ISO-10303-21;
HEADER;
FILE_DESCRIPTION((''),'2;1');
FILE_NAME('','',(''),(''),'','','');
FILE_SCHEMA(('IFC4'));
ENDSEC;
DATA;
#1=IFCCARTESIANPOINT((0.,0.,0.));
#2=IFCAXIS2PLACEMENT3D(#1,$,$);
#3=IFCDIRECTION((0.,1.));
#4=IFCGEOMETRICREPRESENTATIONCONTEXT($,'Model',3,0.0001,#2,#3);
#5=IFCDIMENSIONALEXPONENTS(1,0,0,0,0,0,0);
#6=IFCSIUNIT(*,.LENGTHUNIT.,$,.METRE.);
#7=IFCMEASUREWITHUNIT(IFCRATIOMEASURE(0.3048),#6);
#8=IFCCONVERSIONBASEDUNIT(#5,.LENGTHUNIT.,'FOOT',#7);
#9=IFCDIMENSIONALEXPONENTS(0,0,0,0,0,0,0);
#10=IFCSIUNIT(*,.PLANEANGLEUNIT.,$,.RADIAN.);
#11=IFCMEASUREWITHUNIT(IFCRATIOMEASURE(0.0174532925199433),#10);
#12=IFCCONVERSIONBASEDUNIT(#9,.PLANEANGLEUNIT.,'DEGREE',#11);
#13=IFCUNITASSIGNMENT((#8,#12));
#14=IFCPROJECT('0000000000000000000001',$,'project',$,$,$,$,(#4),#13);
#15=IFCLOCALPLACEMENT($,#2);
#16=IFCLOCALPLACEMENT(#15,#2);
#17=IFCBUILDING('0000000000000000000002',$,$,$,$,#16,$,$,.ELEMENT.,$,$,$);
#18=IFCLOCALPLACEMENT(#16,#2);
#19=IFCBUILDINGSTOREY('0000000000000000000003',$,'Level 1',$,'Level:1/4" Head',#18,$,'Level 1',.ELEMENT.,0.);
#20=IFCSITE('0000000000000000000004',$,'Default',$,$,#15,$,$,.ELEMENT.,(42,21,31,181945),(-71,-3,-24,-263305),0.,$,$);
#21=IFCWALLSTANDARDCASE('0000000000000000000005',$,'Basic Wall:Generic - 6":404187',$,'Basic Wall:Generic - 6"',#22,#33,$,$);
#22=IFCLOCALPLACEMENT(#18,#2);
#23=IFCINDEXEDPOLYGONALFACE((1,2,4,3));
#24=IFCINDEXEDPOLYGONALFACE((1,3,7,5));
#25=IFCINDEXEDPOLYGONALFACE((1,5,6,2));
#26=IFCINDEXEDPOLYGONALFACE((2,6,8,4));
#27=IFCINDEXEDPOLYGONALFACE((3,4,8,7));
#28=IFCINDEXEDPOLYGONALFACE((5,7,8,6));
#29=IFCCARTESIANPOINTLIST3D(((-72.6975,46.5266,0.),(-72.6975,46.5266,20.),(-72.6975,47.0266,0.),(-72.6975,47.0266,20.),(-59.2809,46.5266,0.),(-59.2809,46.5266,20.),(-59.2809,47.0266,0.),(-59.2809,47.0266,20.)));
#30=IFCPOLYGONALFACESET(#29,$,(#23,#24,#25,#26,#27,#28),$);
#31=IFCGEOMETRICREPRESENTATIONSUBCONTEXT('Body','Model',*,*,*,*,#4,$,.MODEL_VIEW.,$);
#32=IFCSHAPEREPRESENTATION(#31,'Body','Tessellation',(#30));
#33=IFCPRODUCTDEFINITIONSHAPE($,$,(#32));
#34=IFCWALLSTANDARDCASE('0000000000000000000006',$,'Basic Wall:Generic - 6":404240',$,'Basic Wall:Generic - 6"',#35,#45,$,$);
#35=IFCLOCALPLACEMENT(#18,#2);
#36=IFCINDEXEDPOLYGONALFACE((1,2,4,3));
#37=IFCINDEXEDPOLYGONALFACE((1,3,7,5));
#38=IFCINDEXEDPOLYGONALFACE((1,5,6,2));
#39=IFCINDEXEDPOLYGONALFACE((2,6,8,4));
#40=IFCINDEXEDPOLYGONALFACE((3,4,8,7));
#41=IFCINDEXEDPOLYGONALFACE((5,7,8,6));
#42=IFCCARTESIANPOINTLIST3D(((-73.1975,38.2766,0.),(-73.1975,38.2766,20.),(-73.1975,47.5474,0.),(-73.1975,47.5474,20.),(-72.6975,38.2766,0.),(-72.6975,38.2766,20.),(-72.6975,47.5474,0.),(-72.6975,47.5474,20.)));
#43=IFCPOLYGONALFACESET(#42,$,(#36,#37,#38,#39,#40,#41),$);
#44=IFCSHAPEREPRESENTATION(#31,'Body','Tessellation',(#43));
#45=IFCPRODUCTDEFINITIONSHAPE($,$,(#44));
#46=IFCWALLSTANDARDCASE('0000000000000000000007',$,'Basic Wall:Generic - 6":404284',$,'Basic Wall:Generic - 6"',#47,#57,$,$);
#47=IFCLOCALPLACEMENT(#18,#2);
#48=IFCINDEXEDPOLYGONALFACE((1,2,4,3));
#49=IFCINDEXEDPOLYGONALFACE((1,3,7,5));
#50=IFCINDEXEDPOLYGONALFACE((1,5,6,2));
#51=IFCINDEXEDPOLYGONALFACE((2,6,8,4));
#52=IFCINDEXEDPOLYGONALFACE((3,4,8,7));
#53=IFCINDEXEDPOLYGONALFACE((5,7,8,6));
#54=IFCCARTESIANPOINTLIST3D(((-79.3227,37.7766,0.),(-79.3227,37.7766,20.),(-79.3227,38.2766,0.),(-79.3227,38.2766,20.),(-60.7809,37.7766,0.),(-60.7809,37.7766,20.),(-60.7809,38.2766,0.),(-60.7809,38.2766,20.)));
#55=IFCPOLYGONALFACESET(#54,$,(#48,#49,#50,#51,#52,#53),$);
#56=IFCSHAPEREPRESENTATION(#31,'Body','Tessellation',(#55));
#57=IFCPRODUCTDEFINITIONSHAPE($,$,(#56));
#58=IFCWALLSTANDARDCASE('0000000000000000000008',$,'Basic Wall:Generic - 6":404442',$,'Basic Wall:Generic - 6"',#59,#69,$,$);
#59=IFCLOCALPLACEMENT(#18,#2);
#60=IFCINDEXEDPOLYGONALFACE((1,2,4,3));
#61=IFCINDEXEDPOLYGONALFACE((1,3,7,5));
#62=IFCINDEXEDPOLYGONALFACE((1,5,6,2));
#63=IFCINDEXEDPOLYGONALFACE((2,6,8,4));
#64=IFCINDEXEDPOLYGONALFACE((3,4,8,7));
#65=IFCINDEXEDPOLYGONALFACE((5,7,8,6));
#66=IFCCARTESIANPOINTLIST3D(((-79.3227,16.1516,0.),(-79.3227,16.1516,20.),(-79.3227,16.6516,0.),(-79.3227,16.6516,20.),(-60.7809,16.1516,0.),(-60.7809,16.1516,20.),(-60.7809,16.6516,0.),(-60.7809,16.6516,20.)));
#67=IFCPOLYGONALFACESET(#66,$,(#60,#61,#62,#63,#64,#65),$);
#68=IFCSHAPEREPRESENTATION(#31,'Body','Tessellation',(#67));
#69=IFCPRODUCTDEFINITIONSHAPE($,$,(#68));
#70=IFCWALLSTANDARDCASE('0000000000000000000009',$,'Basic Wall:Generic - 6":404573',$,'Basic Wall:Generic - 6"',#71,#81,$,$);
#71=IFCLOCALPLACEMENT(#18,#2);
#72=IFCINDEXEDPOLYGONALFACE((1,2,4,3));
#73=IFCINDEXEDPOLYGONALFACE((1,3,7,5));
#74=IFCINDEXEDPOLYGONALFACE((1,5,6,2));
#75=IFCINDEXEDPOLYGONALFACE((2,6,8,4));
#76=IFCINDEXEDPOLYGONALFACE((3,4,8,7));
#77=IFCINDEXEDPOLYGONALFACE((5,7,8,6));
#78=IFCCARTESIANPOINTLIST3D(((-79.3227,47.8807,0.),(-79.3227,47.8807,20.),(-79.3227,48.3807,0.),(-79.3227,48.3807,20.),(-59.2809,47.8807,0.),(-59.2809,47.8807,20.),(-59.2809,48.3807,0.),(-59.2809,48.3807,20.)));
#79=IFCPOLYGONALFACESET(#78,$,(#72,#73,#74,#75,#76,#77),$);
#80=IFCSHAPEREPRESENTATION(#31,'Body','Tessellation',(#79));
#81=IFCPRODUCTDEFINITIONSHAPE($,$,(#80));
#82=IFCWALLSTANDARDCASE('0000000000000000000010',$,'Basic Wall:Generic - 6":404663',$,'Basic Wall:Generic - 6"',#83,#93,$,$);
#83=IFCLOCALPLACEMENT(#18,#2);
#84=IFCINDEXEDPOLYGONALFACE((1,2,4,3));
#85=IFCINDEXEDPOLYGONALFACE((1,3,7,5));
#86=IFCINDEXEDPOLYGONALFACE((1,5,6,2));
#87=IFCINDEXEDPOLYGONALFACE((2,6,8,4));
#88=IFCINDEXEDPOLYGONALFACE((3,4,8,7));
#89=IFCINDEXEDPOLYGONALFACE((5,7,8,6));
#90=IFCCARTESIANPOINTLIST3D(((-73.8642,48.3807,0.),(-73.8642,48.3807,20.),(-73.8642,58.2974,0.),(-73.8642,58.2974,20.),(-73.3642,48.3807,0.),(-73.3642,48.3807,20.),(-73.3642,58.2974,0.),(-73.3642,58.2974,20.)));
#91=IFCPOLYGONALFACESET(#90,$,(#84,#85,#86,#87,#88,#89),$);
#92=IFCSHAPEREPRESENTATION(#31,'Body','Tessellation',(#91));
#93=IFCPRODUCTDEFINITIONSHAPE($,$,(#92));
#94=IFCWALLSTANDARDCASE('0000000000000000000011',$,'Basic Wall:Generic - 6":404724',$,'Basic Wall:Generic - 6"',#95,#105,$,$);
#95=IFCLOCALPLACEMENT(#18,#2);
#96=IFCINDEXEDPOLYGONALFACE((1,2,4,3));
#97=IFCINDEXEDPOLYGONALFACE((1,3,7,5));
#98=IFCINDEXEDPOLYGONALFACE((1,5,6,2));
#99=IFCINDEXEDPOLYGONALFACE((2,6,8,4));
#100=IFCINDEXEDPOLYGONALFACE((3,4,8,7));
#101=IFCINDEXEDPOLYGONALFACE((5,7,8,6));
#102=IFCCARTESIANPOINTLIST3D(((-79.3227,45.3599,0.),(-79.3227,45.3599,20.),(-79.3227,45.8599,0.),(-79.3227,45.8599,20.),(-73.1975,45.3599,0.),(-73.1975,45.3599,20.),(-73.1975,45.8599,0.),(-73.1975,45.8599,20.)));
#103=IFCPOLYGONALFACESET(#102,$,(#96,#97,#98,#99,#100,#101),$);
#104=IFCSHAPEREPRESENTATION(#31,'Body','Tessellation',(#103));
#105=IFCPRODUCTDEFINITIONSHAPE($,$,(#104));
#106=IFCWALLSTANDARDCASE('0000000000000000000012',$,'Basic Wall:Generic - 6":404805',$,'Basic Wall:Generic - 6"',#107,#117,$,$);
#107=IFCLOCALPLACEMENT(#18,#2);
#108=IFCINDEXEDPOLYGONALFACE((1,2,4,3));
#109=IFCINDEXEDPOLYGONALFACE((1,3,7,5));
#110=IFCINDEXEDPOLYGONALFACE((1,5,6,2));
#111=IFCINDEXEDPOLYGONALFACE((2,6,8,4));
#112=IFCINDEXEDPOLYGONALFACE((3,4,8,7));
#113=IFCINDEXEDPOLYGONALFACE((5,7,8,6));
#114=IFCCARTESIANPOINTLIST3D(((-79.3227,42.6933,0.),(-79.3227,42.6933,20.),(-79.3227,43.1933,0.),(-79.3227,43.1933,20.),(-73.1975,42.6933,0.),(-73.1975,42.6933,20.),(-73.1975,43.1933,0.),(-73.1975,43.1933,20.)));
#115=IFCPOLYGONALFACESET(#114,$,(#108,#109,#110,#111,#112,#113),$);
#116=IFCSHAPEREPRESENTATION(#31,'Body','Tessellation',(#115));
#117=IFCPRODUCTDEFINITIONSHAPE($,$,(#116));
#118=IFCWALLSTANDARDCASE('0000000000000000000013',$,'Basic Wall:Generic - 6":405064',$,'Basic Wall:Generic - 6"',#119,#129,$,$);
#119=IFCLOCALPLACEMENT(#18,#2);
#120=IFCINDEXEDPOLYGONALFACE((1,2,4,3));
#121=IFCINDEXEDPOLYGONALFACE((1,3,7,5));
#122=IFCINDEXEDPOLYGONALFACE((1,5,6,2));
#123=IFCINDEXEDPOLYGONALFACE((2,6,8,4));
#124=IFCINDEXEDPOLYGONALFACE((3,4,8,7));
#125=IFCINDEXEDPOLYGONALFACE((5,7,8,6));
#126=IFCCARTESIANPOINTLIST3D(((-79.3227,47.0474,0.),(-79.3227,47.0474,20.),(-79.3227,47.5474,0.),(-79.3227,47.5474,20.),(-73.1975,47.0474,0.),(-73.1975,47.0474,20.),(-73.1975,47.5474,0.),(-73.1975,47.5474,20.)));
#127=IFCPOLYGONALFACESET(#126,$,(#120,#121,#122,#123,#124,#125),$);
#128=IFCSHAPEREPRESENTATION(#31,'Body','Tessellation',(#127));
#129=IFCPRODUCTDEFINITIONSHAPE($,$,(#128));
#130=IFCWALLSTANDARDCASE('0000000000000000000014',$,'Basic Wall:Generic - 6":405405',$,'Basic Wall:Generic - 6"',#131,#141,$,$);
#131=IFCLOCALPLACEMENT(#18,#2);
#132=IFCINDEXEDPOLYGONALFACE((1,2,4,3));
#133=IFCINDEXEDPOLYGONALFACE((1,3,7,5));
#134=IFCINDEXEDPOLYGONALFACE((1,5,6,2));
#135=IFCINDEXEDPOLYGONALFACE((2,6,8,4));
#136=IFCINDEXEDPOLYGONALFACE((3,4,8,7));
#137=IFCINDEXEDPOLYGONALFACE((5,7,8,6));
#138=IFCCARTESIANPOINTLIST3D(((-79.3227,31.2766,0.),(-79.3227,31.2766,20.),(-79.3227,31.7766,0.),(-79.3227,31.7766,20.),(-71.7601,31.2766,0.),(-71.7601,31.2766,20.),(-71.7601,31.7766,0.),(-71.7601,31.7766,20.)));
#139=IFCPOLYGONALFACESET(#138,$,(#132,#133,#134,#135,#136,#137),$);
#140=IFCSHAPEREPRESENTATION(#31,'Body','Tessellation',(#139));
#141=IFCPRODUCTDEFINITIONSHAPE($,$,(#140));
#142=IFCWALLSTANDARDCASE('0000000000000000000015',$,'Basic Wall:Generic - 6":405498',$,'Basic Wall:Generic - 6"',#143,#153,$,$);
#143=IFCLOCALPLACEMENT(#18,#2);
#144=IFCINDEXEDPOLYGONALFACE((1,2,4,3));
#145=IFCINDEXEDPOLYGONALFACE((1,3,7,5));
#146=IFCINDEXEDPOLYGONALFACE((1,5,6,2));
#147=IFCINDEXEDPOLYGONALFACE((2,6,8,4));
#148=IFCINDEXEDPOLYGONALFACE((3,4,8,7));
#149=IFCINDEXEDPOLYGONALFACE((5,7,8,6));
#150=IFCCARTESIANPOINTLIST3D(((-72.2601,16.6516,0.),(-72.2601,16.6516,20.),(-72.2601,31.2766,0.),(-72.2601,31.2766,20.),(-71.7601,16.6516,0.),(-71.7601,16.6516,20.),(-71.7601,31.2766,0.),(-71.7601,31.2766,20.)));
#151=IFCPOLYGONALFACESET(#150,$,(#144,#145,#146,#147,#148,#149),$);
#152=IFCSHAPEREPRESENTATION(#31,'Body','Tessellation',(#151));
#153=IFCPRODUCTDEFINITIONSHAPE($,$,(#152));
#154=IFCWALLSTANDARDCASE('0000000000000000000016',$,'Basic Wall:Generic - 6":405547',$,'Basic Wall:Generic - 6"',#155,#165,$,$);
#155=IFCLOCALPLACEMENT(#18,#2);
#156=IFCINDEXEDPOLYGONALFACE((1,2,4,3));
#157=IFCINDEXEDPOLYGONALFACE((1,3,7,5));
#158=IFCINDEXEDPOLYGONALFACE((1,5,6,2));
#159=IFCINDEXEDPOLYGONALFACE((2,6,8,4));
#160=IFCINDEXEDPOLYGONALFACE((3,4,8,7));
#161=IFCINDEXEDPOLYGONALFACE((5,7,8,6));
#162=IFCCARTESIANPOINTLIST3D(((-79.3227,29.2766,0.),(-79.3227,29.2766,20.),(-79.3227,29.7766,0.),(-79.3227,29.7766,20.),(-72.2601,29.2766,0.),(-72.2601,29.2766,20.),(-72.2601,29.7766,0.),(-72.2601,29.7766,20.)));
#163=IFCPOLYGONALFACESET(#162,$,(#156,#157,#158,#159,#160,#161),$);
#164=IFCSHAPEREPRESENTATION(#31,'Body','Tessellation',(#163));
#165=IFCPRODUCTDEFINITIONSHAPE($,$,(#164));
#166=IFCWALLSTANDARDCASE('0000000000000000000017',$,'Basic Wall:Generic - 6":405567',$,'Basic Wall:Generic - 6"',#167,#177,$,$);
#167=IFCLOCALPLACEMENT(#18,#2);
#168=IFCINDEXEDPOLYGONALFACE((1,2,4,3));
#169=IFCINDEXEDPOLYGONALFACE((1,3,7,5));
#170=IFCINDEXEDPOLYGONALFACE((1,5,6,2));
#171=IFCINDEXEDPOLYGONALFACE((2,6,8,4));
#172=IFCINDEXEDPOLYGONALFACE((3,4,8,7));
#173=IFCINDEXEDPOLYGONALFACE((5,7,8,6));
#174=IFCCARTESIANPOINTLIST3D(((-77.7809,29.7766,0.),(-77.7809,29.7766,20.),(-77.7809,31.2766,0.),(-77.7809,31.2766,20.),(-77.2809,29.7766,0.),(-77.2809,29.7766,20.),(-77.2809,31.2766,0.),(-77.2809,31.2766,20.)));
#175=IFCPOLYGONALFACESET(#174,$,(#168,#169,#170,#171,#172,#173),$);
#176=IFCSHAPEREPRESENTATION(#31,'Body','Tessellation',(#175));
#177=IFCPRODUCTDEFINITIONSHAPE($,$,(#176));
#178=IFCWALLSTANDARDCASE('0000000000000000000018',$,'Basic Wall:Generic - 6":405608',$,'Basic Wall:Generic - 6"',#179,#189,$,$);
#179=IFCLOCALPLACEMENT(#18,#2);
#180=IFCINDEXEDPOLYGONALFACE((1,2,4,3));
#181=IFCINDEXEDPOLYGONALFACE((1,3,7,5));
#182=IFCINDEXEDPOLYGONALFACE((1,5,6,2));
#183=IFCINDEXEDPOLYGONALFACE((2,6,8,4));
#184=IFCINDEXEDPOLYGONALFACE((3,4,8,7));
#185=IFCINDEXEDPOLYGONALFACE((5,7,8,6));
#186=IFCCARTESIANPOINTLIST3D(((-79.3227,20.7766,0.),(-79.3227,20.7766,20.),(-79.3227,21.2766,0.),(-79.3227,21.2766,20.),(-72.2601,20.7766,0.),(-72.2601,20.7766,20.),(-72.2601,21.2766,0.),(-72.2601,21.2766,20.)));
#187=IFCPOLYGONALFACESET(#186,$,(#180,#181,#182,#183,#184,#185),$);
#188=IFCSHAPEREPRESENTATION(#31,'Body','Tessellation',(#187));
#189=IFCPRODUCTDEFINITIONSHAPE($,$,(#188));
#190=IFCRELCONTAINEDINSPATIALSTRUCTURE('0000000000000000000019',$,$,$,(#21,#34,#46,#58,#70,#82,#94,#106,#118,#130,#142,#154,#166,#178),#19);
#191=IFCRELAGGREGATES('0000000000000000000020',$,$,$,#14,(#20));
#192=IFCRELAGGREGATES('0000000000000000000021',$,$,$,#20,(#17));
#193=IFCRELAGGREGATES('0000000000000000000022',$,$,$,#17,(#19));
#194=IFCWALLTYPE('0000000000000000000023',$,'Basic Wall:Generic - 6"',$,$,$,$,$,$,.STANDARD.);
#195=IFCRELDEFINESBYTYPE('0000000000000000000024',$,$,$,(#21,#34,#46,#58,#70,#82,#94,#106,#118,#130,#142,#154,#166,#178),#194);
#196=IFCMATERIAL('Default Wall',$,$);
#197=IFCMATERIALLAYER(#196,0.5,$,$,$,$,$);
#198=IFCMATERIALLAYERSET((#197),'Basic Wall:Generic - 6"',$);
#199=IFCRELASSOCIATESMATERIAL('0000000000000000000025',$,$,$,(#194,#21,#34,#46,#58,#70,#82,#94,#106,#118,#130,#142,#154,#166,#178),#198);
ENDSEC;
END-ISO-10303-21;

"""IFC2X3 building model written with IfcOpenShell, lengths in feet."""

from ifc_helpers import new_model, entity, si_unit, converted_unit, direction, frame, frame_2d, origin, place, context, subcontext, project, spatial, rectangle, extrude, material, layer, layer_set, layer_usage, type_object, element, save


model = new_model("IFC2X3")

# Units and contexts
model_context = context("Model", 3, precision=0.0001, world=origin(), true_north=direction((0.0, 1.0)))
body_context = subcontext(model_context, "Body", "Model", "MODEL_VIEW")
ifc_project = project(units=[converted_unit("LENGTHUNIT", "FOOT", entity("IfcRatioMeasure", 0.3048), si_unit("LENGTHUNIT", "METRE"), dimensions=[1, 0, 0, 0, 0, 0, 0]), converted_unit("PLANEANGLEUNIT", "DEGREE", entity("IfcRatioMeasure", 0.0174532925199433), si_unit("PLANEANGLEUNIT", "RADIAN"), dimensions=[0, 0, 0, 0, 0, 0, 0])], contexts=[model_context])

# Site, building, storey
site_placement = place(None, origin())
site = spatial("IfcSite", under=ifc_project, at=site_placement, Name="Default", CompositionType="ELEMENT", RefLatitude=(42, 21, 31, 181945), RefLongitude=(-71, -3, -24, -263305), RefElevation=0.0)
building_placement = place(site_placement, origin())
building = spatial("IfcBuilding", under=site, at=building_placement, CompositionType="ELEMENT")
storey_placement = place(building_placement, origin())
storey = spatial("IfcBuildingStorey", under=building, at=storey_placement, Name="Level 1", ObjectType="Level:1/4\" Head", LongName="Level 1", CompositionType="ELEMENT", Elevation=0.0)

# Walls
ifc_material = material(Name="Default Wall")
ifc_layer_1 = layer(ifc_material, 0.5)
ifc_layer_set_1 = layer_set([ifc_layer_1], Name="Basic Wall:Generic - 6\"")
wall_type_1 = type_object("IfcWallType", Name="Basic Wall:Generic - 6\"", PredefinedType="STANDARD", material=ifc_layer_set_1)
ifc_layer_usage_1 = layer_usage(ifc_layer_set_1, "AXIS2", "NEGATIVE", 0.25)
wall_1_placement = place(storey_placement, frame((-59.2809, 46.7766, 0.0), z_axis=(0.0, 0.0, 1.0), x_axis=(-1.0, 0.0, 0.0)))
element("IfcWallStandardCase", 1, at=wall_1_placement, inside=storey, type_object=wall_type_1, material=ifc_layer_usage_1, Name="Basic Wall:Generic - 6\":404187", ObjectType="Basic Wall:Generic - 6\"", context=body_context, shape_type="SweptSolid", body=[
    extrude(rectangle(XDim=13.4167, YDim=0.5, at=frame_2d((6.7083, 0.0), x_axis=(-1.0, 0.0))), origin(), (0.0, 0.0, 1.0), 20.0),
])
ifc_layer_usage_2 = layer_usage(ifc_layer_set_1, "AXIS2", "NEGATIVE", 0.25)
wall_2_placement = place(storey_placement, frame((-72.9475, 47.5474, 0.0), z_axis=(0.0, 0.0, 1.0), x_axis=(0.0, -1.0, 0.0)))
element("IfcWallStandardCase", 2, at=wall_2_placement, inside=storey, type_object=wall_type_1, material=ifc_layer_usage_2, Name="Basic Wall:Generic - 6\":404240", ObjectType="Basic Wall:Generic - 6\"", context=body_context, shape_type="SweptSolid", body=[
    extrude(rectangle(XDim=9.2708, YDim=0.5, at=frame_2d((4.6354, 0.0), x_axis=(-1.0, 0.0))), origin(), (0.0, 0.0, 1.0), 20.0),
])
ifc_layer_usage_3 = layer_usage(ifc_layer_set_1, "AXIS2", "NEGATIVE", 0.25)
wall_3_placement = place(storey_placement, frame((-60.7809, 38.0266, 0.0), z_axis=(0.0, 0.0, 1.0), x_axis=(-1.0, 0.0, 0.0)))
element("IfcWallStandardCase", 3, at=wall_3_placement, inside=storey, type_object=wall_type_1, material=ifc_layer_usage_3, Name="Basic Wall:Generic - 6\":404284", ObjectType="Basic Wall:Generic - 6\"", context=body_context, shape_type="SweptSolid", body=[
    extrude(rectangle(XDim=18.5418, YDim=0.5, at=frame_2d((9.2709, 0.0), x_axis=(-1.0, 0.0))), origin(), (0.0, 0.0, 1.0), 20.0),
])
ifc_layer_usage_4 = layer_usage(ifc_layer_set_1, "AXIS2", "NEGATIVE", 0.25)
wall_4_placement = place(storey_placement, frame((-60.7809, 16.4016, 0.0), z_axis=(0.0, 0.0, 1.0), x_axis=(-1.0, 0.0, 0.0)))
element("IfcWallStandardCase", 4, at=wall_4_placement, inside=storey, type_object=wall_type_1, material=ifc_layer_usage_4, Name="Basic Wall:Generic - 6\":404442", ObjectType="Basic Wall:Generic - 6\"", context=body_context, shape_type="SweptSolid", body=[
    extrude(rectangle(XDim=18.5418, YDim=0.5, at=frame_2d((9.2709, 0.0), x_axis=(-1.0, 0.0))), origin(), (0.0, 0.0, 1.0), 20.0),
])
ifc_layer_usage_5 = layer_usage(ifc_layer_set_1, "AXIS2", "NEGATIVE", 0.25)
wall_5_placement = place(storey_placement, frame((-79.3227, 48.1307, 0.0)))
element("IfcWallStandardCase", 5, at=wall_5_placement, inside=storey, type_object=wall_type_1, material=ifc_layer_usage_5, Name="Basic Wall:Generic - 6\":404573", ObjectType="Basic Wall:Generic - 6\"", context=body_context, shape_type="SweptSolid", body=[
    extrude(rectangle(XDim=20.0418, YDim=0.5, at=frame_2d((10.0209, 0.0), x_axis=(-1.0, 0.0))), origin(), (0.0, 0.0, 1.0), 20.0),
])
ifc_layer_usage_6 = layer_usage(ifc_layer_set_1, "AXIS2", "NEGATIVE", 0.25)
wall_6_placement = place(storey_placement, frame((-73.6142, 58.2974, 0.0), z_axis=(0.0, 0.0, 1.0), x_axis=(0.0, -1.0, 0.0)))
element("IfcWallStandardCase", 6, at=wall_6_placement, inside=storey, type_object=wall_type_1, material=ifc_layer_usage_6, Name="Basic Wall:Generic - 6\":404663", ObjectType="Basic Wall:Generic - 6\"", context=body_context, shape_type="SweptSolid", body=[
    extrude(rectangle(XDim=9.9167, YDim=0.5, at=frame_2d((4.9583, 0.0), x_axis=(-1.0, 0.0))), origin(), (0.0, 0.0, 1.0), 20.0),
])
ifc_layer_usage_7 = layer_usage(ifc_layer_set_1, "AXIS2", "NEGATIVE", 0.25)
wall_7_placement = place(storey_placement, frame((-79.3227, 45.6099, 0.0)))
element("IfcWallStandardCase", 7, at=wall_7_placement, inside=storey, type_object=wall_type_1, material=ifc_layer_usage_7, Name="Basic Wall:Generic - 6\":404724", ObjectType="Basic Wall:Generic - 6\"", context=body_context, shape_type="SweptSolid", body=[
    extrude(rectangle(XDim=6.1252, YDim=0.5, at=frame_2d((3.0626, 0.0), x_axis=(-1.0, 0.0))), origin(), (0.0, 0.0, 1.0), 20.0),
])
ifc_layer_usage_8 = layer_usage(ifc_layer_set_1, "AXIS2", "NEGATIVE", 0.25)
wall_8_placement = place(storey_placement, frame((-73.1975, 42.9433, 0.0), z_axis=(0.0, 0.0, 1.0), x_axis=(-1.0, 0.0, 0.0)))
element("IfcWallStandardCase", 8, at=wall_8_placement, inside=storey, type_object=wall_type_1, material=ifc_layer_usage_8, Name="Basic Wall:Generic - 6\":404805", ObjectType="Basic Wall:Generic - 6\"", context=body_context, shape_type="SweptSolid", body=[
    extrude(rectangle(XDim=6.1252, YDim=0.5, at=frame_2d((3.0626, 0.0), x_axis=(-1.0, 0.0))), origin(), (0.0, 0.0, 1.0), 20.0),
])
ifc_layer_usage_9 = layer_usage(ifc_layer_set_1, "AXIS2", "NEGATIVE", 0.25)
wall_9_placement = place(storey_placement, frame((-79.3227, 47.2974, 0.0)))
element("IfcWallStandardCase", 9, at=wall_9_placement, inside=storey, type_object=wall_type_1, material=ifc_layer_usage_9, Name="Basic Wall:Generic - 6\":405064", ObjectType="Basic Wall:Generic - 6\"", context=body_context, shape_type="SweptSolid", body=[
    extrude(rectangle(XDim=6.1252, YDim=0.5, at=frame_2d((3.0626, 0.0), x_axis=(-1.0, 0.0))), origin(), (0.0, 0.0, 1.0), 20.0),
])
ifc_layer_usage_10 = layer_usage(ifc_layer_set_1, "AXIS2", "NEGATIVE", 0.25)
wall_10_placement = place(storey_placement, frame((-79.3227, 31.5266, 0.0)))
element("IfcWallStandardCase", 10, at=wall_10_placement, inside=storey, type_object=wall_type_1, material=ifc_layer_usage_10, Name="Basic Wall:Generic - 6\":405405", ObjectType="Basic Wall:Generic - 6\"", context=body_context, shape_type="SweptSolid", body=[
    extrude(rectangle(XDim=7.5626, YDim=0.5, at=frame_2d((3.7813, 0.0), x_axis=(-1.0, 0.0))), origin(), (0.0, 0.0, 1.0), 20.0),
])
ifc_layer_usage_11 = layer_usage(ifc_layer_set_1, "AXIS2", "NEGATIVE", 0.25)
wall_11_placement = place(storey_placement, frame((-72.0101, 31.2766, 0.0), z_axis=(0.0, 0.0, 1.0), x_axis=(0.0, -1.0, 0.0)))
element("IfcWallStandardCase", 11, at=wall_11_placement, inside=storey, type_object=wall_type_1, material=ifc_layer_usage_11, Name="Basic Wall:Generic - 6\":405498", ObjectType="Basic Wall:Generic - 6\"", context=body_context, shape_type="SweptSolid", body=[
    extrude(rectangle(XDim=14.625, YDim=0.5, at=frame_2d((7.3125, 0.0), x_axis=(-1.0, 0.0))), origin(), (0.0, 0.0, 1.0), 20.0),
])
ifc_layer_usage_12 = layer_usage(ifc_layer_set_1, "AXIS2", "NEGATIVE", 0.25)
wall_12_placement = place(storey_placement, frame((-79.3227, 29.5266, 0.0)))
element("IfcWallStandardCase", 12, at=wall_12_placement, inside=storey, type_object=wall_type_1, material=ifc_layer_usage_12, Name="Basic Wall:Generic - 6\":405547", ObjectType="Basic Wall:Generic - 6\"", context=body_context, shape_type="SweptSolid", body=[
    extrude(rectangle(XDim=7.0626, YDim=0.5, at=frame_2d((3.5313, 0.0), x_axis=(-1.0, 0.0))), origin(), (0.0, 0.0, 1.0), 20.0),
])
ifc_layer_usage_13 = layer_usage(ifc_layer_set_1, "AXIS2", "NEGATIVE", 0.25)
wall_13_placement = place(storey_placement, frame((-77.5309, 29.7766, 0.0), z_axis=(0.0, 0.0, 1.0), x_axis=(0.0, 1.0, 0.0)))
element("IfcWallStandardCase", 13, at=wall_13_placement, inside=storey, type_object=wall_type_1, material=ifc_layer_usage_13, Name="Basic Wall:Generic - 6\":405567", ObjectType="Basic Wall:Generic - 6\"", context=body_context, shape_type="SweptSolid", body=[
    extrude(rectangle(XDim=1.5, YDim=0.5, at=frame_2d((0.75, 0.0), x_axis=(-1.0, 0.0))), origin(), (0.0, 0.0, 1.0), 20.0),
])
ifc_layer_usage_14 = layer_usage(ifc_layer_set_1, "AXIS2", "NEGATIVE", 0.25)
wall_14_placement = place(storey_placement, frame((-79.3227, 21.0266, 0.0)))
element("IfcWallStandardCase", 14, at=wall_14_placement, inside=storey, type_object=wall_type_1, material=ifc_layer_usage_14, Name="Basic Wall:Generic - 6\":405608", ObjectType="Basic Wall:Generic - 6\"", context=body_context, shape_type="SweptSolid", body=[
    extrude(rectangle(XDim=7.0626, YDim=0.5, at=frame_2d((3.5313, 0.0), x_axis=(-1.0, 0.0))), origin(), (0.0, 0.0, 1.0), 20.0),
])

save(model, "model.ifc")
